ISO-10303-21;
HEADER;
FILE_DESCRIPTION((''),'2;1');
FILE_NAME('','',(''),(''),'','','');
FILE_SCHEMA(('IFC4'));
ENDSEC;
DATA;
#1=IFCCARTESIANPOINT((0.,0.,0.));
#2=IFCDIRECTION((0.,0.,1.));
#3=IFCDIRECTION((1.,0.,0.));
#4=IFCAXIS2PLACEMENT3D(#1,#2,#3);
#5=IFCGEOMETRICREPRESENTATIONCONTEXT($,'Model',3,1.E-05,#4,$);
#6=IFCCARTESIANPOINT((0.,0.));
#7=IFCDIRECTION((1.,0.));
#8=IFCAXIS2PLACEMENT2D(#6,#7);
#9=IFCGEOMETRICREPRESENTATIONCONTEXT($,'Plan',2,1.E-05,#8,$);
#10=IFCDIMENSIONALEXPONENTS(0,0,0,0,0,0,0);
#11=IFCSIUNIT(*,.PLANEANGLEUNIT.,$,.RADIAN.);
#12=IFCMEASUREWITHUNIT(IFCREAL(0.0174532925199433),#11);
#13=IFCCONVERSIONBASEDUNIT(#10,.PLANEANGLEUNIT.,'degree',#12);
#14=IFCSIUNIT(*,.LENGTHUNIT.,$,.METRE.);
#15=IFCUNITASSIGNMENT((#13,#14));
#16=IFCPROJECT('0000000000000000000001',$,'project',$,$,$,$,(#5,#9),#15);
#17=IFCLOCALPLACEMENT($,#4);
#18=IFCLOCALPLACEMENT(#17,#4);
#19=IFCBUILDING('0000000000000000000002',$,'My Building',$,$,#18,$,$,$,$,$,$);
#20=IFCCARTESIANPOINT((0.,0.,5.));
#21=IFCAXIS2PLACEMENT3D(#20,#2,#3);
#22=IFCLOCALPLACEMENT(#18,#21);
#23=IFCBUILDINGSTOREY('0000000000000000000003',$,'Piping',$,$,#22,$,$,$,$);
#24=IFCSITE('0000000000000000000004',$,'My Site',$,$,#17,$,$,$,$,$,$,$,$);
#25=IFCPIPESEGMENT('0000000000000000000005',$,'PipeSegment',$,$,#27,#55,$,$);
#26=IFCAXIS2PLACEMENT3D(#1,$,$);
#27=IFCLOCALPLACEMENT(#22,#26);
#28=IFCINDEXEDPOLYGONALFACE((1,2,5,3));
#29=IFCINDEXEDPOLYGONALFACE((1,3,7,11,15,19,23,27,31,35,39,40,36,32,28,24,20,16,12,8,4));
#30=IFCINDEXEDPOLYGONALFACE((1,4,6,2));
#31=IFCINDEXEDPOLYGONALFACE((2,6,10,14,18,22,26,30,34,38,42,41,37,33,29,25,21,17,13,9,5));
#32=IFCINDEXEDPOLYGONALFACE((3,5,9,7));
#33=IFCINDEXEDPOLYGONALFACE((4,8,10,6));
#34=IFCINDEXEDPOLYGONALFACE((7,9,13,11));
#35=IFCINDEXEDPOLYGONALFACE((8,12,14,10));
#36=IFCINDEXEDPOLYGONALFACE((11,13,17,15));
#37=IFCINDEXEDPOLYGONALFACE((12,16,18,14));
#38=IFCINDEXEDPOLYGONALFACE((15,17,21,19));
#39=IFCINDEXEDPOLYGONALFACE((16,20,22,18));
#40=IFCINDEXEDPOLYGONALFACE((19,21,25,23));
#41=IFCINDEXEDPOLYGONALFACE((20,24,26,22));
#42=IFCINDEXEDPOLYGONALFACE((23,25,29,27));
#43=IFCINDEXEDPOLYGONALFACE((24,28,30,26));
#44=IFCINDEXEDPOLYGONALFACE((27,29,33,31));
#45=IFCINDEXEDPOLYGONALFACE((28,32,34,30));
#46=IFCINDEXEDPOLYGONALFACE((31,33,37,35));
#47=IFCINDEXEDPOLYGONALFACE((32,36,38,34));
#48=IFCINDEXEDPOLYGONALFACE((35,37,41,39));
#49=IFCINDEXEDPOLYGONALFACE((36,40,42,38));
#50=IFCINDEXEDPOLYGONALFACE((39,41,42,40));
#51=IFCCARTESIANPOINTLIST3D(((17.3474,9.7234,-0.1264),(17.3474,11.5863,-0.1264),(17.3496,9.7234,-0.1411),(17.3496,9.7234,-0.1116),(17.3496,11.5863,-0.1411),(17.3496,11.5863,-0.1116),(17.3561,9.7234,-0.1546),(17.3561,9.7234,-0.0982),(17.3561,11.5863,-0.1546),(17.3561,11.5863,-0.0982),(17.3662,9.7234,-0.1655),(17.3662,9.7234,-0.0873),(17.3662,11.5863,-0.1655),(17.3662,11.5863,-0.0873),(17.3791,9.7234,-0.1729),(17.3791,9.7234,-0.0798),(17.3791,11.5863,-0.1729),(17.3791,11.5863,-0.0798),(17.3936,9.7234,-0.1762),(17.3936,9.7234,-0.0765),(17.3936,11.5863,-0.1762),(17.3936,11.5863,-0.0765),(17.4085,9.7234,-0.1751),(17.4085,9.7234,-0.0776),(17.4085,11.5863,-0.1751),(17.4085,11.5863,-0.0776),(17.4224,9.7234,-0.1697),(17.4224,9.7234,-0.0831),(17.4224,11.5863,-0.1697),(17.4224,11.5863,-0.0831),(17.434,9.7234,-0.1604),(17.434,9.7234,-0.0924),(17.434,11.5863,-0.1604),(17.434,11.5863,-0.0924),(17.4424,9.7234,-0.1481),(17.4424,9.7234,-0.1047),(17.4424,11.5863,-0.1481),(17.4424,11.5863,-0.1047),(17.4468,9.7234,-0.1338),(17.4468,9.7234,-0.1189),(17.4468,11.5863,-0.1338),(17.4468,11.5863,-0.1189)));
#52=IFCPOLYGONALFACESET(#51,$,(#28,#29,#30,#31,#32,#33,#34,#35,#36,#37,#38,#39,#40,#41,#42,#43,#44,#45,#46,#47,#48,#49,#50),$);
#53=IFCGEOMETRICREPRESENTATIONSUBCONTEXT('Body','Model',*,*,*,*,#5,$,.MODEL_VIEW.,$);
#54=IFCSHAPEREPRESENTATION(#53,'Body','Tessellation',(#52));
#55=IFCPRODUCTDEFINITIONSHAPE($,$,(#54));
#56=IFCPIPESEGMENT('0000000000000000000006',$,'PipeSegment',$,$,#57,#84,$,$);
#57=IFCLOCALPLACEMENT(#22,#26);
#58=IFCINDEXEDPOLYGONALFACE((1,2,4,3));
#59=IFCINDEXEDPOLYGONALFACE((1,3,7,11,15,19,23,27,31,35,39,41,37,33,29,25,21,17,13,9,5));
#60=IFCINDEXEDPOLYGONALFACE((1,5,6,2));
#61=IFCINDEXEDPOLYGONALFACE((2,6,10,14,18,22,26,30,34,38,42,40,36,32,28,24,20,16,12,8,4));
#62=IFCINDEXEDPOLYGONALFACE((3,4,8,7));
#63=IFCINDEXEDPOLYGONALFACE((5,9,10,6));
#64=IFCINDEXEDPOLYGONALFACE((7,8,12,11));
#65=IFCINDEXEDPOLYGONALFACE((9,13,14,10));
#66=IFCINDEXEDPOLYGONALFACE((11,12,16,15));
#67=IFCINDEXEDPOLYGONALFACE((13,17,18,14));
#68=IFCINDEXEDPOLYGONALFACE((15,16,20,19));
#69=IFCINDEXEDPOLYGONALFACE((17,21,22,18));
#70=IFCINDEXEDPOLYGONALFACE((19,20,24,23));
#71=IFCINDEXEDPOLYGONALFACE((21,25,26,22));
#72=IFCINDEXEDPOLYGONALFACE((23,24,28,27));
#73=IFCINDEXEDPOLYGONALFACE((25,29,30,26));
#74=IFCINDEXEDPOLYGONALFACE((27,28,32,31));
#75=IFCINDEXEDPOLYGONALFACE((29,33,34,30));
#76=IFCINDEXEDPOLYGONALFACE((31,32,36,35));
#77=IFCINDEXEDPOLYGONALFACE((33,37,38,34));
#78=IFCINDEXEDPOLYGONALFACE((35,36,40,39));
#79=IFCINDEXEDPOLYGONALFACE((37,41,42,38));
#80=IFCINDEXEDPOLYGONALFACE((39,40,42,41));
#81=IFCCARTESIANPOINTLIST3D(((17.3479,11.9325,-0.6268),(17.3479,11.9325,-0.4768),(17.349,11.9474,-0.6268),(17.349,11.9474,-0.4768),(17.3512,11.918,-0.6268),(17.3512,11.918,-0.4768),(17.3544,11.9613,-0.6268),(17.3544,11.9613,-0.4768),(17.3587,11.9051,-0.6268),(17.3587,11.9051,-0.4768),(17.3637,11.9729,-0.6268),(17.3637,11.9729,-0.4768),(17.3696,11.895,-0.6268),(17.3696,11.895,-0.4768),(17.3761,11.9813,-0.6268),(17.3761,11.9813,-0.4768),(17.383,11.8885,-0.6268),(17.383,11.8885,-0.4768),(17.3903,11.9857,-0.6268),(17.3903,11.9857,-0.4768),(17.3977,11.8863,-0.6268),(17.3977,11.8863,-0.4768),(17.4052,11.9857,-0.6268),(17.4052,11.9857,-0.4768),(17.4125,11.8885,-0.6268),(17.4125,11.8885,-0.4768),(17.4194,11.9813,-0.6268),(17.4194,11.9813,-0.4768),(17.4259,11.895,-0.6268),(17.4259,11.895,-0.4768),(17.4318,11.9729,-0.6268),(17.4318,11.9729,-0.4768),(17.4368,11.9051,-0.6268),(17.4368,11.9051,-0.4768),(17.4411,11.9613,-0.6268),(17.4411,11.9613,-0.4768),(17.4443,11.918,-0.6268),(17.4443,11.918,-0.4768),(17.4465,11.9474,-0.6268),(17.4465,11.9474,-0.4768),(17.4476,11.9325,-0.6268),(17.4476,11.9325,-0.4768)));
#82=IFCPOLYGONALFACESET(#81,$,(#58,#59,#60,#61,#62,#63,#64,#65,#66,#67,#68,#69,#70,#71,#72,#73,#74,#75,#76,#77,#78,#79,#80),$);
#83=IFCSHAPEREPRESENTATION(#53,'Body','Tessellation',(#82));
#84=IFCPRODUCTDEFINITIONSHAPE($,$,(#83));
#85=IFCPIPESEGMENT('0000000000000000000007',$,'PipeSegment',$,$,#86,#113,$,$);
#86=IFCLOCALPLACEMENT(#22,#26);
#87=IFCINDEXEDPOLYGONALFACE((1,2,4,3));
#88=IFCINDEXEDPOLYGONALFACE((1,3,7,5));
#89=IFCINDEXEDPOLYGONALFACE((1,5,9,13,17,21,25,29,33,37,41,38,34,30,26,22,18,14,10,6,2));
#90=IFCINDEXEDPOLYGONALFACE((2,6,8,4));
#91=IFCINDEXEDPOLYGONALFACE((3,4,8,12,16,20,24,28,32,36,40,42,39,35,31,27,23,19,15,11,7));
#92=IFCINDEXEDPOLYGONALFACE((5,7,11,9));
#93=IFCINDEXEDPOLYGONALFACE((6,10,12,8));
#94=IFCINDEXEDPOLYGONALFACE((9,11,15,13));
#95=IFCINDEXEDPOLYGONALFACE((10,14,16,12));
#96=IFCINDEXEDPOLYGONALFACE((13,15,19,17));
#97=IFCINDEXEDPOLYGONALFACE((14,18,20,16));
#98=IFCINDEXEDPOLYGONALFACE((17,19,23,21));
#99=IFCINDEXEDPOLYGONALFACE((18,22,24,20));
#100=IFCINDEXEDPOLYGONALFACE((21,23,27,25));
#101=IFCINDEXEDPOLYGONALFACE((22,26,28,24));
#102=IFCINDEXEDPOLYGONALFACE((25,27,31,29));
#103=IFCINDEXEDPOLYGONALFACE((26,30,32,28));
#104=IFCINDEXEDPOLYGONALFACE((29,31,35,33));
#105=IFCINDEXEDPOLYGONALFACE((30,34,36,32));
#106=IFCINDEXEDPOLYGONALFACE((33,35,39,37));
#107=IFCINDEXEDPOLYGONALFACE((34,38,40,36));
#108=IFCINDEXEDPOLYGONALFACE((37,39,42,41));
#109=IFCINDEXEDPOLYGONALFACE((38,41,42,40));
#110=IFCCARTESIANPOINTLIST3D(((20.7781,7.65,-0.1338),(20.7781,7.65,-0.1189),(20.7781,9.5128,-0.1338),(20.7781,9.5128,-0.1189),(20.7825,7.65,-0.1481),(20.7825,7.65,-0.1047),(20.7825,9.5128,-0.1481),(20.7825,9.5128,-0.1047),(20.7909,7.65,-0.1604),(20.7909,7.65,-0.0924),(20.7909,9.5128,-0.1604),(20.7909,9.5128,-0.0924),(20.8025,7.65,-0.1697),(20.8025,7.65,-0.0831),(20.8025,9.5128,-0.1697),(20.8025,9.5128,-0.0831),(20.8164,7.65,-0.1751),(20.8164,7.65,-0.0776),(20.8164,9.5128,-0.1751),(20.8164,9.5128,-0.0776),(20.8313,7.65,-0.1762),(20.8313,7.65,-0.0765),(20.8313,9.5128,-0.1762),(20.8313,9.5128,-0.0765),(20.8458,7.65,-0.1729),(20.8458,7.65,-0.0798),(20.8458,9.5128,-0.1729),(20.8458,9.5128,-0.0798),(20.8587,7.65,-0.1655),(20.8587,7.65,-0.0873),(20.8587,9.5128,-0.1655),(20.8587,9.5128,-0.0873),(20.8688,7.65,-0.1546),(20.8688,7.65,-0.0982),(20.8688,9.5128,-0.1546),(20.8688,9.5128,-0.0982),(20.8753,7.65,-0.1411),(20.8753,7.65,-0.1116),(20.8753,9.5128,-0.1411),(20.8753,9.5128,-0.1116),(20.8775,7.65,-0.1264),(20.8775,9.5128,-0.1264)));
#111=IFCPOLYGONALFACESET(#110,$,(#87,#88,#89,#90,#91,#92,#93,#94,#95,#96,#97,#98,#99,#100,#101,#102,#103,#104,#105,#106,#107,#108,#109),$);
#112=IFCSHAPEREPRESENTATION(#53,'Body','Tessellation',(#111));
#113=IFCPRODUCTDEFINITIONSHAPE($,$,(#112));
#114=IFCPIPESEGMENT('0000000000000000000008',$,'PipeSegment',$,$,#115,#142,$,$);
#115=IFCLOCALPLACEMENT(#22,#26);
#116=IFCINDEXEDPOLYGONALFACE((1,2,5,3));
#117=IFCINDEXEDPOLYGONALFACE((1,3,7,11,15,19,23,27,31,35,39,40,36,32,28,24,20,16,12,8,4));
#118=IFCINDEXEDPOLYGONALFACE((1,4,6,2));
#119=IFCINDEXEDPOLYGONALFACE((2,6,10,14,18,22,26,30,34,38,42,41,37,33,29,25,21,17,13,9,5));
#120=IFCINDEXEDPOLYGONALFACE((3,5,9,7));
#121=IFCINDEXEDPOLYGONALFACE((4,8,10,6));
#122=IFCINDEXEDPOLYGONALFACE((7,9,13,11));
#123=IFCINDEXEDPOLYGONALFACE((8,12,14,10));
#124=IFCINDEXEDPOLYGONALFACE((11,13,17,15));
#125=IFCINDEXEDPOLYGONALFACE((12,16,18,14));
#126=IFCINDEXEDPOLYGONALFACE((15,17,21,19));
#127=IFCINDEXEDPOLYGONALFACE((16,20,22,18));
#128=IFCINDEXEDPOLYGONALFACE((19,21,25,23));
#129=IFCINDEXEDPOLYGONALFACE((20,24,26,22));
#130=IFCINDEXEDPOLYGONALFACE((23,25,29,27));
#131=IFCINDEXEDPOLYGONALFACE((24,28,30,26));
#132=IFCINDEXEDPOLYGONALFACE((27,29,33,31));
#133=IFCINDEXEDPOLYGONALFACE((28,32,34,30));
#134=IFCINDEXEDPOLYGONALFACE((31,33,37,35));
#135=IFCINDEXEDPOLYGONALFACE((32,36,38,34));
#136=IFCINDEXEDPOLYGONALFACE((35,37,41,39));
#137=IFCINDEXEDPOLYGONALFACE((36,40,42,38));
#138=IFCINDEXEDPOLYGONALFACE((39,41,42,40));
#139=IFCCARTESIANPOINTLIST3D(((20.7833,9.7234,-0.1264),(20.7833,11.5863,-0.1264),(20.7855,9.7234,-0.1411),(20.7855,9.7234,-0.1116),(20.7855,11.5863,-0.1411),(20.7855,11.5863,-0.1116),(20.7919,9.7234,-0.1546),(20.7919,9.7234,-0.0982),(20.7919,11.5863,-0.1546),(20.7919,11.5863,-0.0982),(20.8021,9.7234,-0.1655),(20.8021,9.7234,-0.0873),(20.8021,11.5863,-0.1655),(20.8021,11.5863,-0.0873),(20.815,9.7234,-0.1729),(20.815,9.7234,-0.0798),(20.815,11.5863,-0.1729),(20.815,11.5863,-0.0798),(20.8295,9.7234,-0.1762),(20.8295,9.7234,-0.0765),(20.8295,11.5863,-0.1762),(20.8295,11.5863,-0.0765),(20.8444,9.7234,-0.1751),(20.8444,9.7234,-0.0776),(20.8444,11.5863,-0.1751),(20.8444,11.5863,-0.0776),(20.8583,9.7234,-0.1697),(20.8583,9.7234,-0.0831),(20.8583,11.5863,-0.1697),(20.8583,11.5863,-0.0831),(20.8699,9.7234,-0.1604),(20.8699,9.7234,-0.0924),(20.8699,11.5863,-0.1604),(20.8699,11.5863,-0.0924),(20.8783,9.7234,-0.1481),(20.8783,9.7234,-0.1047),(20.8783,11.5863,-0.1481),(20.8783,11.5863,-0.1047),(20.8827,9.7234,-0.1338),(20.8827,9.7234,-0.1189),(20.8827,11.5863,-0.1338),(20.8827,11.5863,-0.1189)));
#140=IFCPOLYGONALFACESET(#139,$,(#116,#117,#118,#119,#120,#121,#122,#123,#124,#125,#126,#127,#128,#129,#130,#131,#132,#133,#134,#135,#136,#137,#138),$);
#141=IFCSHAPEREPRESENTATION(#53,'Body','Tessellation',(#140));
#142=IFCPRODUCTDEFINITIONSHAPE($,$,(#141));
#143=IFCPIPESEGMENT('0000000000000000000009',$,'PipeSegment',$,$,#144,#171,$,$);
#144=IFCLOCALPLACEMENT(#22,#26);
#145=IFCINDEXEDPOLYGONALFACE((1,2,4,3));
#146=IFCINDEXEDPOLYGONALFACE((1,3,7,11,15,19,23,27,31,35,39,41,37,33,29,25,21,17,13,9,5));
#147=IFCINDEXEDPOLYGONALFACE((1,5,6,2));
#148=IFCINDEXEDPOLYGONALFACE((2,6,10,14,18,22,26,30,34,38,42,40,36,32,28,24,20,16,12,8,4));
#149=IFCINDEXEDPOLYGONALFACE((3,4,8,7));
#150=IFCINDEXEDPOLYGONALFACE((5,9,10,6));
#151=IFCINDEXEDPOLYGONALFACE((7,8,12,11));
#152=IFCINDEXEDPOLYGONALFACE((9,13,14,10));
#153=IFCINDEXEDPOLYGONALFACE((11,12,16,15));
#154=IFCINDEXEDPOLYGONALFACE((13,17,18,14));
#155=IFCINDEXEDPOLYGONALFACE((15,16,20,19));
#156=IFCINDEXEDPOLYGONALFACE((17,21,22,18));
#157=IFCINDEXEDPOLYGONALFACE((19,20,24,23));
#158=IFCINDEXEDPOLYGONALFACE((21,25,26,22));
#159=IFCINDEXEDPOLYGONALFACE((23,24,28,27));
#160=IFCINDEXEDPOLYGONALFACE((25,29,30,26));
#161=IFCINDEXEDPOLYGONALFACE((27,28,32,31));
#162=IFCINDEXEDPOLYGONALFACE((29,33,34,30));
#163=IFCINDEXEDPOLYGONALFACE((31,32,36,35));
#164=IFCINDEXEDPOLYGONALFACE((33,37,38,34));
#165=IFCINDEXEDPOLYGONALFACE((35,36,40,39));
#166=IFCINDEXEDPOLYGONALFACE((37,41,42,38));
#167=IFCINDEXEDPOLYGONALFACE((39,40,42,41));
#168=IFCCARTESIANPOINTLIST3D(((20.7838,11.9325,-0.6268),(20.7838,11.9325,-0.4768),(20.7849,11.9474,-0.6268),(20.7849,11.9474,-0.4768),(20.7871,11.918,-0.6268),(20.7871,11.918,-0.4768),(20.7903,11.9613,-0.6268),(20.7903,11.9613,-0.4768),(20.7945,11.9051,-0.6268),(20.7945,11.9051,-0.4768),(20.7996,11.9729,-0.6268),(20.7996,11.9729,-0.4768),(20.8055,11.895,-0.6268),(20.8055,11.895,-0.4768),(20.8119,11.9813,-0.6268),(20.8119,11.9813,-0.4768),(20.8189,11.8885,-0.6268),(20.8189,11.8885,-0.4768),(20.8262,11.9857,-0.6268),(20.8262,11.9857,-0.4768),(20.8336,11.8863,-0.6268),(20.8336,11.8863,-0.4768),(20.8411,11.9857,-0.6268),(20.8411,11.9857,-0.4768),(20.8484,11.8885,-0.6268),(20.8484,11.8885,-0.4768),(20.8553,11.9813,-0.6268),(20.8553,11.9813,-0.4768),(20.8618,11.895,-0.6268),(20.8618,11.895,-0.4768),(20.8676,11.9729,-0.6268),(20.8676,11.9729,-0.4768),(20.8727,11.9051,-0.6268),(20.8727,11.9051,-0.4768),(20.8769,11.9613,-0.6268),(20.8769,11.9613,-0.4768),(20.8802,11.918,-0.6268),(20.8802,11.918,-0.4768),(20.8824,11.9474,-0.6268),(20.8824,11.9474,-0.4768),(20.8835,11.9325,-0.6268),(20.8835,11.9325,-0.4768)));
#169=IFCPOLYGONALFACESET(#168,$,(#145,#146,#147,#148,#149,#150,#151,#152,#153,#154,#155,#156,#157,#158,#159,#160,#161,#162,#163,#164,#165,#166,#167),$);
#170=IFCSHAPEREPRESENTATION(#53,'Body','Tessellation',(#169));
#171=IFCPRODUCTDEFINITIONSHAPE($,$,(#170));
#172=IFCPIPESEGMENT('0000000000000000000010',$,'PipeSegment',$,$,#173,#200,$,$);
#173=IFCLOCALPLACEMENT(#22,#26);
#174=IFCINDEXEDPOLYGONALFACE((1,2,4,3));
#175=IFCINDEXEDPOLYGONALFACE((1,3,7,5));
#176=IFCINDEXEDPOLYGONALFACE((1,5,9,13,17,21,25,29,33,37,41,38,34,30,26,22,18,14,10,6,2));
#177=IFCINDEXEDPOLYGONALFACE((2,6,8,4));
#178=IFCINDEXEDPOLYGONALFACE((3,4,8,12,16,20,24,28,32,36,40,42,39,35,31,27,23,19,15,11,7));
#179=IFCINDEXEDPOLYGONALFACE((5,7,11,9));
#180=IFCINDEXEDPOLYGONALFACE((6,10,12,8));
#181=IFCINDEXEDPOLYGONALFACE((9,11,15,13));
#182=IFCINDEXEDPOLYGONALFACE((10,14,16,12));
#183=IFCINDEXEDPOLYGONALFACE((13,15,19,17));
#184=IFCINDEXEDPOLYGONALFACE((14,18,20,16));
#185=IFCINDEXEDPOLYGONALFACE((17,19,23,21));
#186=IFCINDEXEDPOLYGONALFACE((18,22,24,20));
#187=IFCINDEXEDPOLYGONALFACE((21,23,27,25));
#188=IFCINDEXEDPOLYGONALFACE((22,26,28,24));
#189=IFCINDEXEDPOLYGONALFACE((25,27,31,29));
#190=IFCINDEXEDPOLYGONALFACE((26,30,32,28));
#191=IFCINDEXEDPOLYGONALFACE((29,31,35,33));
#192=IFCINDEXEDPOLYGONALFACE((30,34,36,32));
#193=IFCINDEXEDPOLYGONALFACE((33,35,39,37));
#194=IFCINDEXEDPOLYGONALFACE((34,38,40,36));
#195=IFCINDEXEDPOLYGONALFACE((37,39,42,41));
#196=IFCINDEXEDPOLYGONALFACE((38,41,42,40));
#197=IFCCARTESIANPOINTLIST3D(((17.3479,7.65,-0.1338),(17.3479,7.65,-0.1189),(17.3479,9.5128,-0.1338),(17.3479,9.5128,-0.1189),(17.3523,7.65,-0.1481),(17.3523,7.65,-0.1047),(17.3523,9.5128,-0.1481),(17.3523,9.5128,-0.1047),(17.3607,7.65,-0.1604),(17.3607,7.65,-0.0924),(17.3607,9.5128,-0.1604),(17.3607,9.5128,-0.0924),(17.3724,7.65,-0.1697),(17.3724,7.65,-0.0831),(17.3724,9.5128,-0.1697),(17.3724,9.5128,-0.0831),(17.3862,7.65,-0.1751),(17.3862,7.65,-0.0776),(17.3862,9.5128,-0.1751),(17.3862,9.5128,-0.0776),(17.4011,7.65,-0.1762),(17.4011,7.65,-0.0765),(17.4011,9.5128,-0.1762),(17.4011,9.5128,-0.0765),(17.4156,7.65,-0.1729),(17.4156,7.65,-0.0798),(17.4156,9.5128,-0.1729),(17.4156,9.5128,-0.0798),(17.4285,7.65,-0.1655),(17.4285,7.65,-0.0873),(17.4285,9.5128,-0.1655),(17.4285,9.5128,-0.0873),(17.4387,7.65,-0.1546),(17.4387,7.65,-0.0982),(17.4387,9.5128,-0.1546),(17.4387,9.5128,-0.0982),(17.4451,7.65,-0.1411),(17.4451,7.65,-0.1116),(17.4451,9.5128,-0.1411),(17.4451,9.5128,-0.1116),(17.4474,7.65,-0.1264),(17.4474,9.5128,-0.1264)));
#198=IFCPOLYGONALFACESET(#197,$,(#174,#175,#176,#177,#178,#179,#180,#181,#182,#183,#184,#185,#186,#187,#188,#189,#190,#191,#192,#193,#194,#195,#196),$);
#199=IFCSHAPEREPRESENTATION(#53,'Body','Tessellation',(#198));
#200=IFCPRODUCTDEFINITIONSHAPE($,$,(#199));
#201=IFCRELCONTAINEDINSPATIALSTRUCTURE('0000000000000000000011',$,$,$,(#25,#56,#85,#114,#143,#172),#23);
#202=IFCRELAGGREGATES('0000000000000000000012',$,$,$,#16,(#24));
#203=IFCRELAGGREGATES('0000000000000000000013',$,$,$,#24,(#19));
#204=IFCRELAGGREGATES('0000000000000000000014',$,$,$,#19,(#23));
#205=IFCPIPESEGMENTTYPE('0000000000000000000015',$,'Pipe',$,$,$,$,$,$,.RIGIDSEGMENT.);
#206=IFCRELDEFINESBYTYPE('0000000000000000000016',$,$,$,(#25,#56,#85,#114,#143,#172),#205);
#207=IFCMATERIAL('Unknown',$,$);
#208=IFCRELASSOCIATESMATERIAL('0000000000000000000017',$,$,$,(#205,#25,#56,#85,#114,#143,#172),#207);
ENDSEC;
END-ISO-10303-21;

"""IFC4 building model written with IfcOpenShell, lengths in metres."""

from ifc_helpers import new_model, entity, si_unit, converted_unit, frame, origin_with_axes, origin_2d_with_axis, place, context, subcontext, project, spatial, circle, extrude, material, material_profile, profile_set, profile_usage, type_object, element, save


model = new_model("IFC4")

# Units and contexts
model_context = context("Model", 3, precision=1e-05, world=origin_with_axes())
plan_context = context("Plan", 2, precision=1e-05, world=origin_2d_with_axis())
body_context = subcontext(model_context, "Body", "Model", "MODEL_VIEW")
ifc_project = project(units=[converted_unit("PLANEANGLEUNIT", "degree", entity("IfcReal", 0.0174532925199433), si_unit("PLANEANGLEUNIT", "RADIAN"), dimensions=[0, 0, 0, 0, 0, 0, 0]), si_unit("LENGTHUNIT", "METRE")], contexts=[model_context, plan_context])

# Site, building, storey
site_placement = place(None, origin_with_axes())
site = spatial("IfcSite", under=ifc_project, at=site_placement, Name="My Site")
building_placement = place(site_placement, origin_with_axes())
building = spatial("IfcBuilding", under=site, at=building_placement, Name="My Building")
storey_placement = place(building_placement, frame((0.0, 0.0, 5.0), z_axis=(0.0, 0.0, 1.0), x_axis=(1.0, 0.0, 0.0)))
storey = spatial("IfcBuildingStorey", under=building, at=storey_placement, Name="Piping")

# Pipe segments
ifc_material = material(Name="Unknown")
ifc_material_profile_1 = material_profile(ifc_material, circle(Radius=0.05))
ifc_profile_set_1 = profile_set([ifc_material_profile_1])
pipe_segment_type = type_object("IfcPipeSegmentType", Name="Pipe", PredefinedType="RIGIDSEGMENT", material=ifc_profile_set_1)
ifc_profile_usage_1 = profile_usage(ifc_profile_set_1, cardinal=5)
pipe_segment_1_placement = place(storey_placement, frame((17.3974, 9.7234, -0.1264), z_axis=(0.0, 1.0, 0.0), x_axis=(-1.0, 0.0, 0.0)))
element("IfcPipeSegment", 1, at=pipe_segment_1_placement, inside=storey, type_object=pipe_segment_type, material=ifc_profile_usage_1, Name="PipeSegment", context=body_context, shape_type="SweptSolid", body=[
    extrude(circle(Radius=0.05), origin_with_axes(), (0.0, 0.0, 1.0), 1.8629),
])
ifc_profile_usage_2 = profile_usage(ifc_profile_set_1, cardinal=5)
pipe_segment_2_placement = place(storey_placement, frame((17.3977, 11.9363, -0.4768), z_axis=(0.0, 0.0, -1.0), x_axis=(-0.000053, -1.0, 0.0)))
element("IfcPipeSegment", 2, at=pipe_segment_2_placement, inside=storey, type_object=pipe_segment_type, material=ifc_profile_usage_2, Name="PipeSegment", context=body_context, shape_type="SweptSolid", body=[
    extrude(circle(Radius=0.05), origin_with_axes(), (0.0, 0.0, 1.0), 0.15),
])
ifc_profile_usage_3 = profile_usage(ifc_profile_set_1, cardinal=5)
pipe_segment_3_placement = place(storey_placement, frame((20.8275, 9.5128, -0.1264), z_axis=(0.0, -1.0, 0.0), x_axis=(1.0, 0.0, 0.0)))
element("IfcPipeSegment", 3, at=pipe_segment_3_placement, inside=storey, type_object=pipe_segment_type, material=ifc_profile_usage_3, Name="PipeSegment", context=body_context, shape_type="SweptSolid", body=[
    extrude(circle(Radius=0.05), origin_with_axes(), (0.0, 0.0, 1.0), 1.8629),
])
ifc_profile_usage_4 = profile_usage(ifc_profile_set_1, cardinal=5)
pipe_segment_4_placement = place(storey_placement, frame((20.8333, 9.7234, -0.1264), z_axis=(0.0, 1.0, 0.0), x_axis=(-1.0, 0.0, 0.0)))
element("IfcPipeSegment", 4, at=pipe_segment_4_placement, inside=storey, type_object=pipe_segment_type, material=ifc_profile_usage_4, Name="PipeSegment", context=body_context, shape_type="SweptSolid", body=[
    extrude(circle(Radius=0.05), origin_with_axes(), (0.0, 0.0, 1.0), 1.8629),
])
ifc_profile_usage_5 = profile_usage(ifc_profile_set_1, cardinal=5)
pipe_segment_5_placement = place(storey_placement, frame((20.8336, 11.9363, -0.4768), z_axis=(0.0, 0.0, -1.0), x_axis=(-0.000053, -1.0, 0.0)))
element("IfcPipeSegment", 5, at=pipe_segment_5_placement, inside=storey, type_object=pipe_segment_type, material=ifc_profile_usage_5, Name="PipeSegment", context=body_context, shape_type="SweptSolid", body=[
    extrude(circle(Radius=0.05), origin_with_axes(), (0.0, 0.0, 1.0), 0.15),
])
ifc_profile_usage_6 = profile_usage(ifc_profile_set_1, cardinal=5)
pipe_segment_6_placement = place(storey_placement, frame((17.3974, 9.5128, -0.1264), z_axis=(0.0, -1.0, 0.0), x_axis=(1.0, 0.0, 0.0)))
element("IfcPipeSegment", 6, at=pipe_segment_6_placement, inside=storey, type_object=pipe_segment_type, material=ifc_profile_usage_6, Name="PipeSegment", context=body_context, shape_type="SweptSolid", body=[
    extrude(circle(Radius=0.05), origin_with_axes(), (0.0, 0.0, 1.0), 1.8629),
])

save(model, "model.ifc")
